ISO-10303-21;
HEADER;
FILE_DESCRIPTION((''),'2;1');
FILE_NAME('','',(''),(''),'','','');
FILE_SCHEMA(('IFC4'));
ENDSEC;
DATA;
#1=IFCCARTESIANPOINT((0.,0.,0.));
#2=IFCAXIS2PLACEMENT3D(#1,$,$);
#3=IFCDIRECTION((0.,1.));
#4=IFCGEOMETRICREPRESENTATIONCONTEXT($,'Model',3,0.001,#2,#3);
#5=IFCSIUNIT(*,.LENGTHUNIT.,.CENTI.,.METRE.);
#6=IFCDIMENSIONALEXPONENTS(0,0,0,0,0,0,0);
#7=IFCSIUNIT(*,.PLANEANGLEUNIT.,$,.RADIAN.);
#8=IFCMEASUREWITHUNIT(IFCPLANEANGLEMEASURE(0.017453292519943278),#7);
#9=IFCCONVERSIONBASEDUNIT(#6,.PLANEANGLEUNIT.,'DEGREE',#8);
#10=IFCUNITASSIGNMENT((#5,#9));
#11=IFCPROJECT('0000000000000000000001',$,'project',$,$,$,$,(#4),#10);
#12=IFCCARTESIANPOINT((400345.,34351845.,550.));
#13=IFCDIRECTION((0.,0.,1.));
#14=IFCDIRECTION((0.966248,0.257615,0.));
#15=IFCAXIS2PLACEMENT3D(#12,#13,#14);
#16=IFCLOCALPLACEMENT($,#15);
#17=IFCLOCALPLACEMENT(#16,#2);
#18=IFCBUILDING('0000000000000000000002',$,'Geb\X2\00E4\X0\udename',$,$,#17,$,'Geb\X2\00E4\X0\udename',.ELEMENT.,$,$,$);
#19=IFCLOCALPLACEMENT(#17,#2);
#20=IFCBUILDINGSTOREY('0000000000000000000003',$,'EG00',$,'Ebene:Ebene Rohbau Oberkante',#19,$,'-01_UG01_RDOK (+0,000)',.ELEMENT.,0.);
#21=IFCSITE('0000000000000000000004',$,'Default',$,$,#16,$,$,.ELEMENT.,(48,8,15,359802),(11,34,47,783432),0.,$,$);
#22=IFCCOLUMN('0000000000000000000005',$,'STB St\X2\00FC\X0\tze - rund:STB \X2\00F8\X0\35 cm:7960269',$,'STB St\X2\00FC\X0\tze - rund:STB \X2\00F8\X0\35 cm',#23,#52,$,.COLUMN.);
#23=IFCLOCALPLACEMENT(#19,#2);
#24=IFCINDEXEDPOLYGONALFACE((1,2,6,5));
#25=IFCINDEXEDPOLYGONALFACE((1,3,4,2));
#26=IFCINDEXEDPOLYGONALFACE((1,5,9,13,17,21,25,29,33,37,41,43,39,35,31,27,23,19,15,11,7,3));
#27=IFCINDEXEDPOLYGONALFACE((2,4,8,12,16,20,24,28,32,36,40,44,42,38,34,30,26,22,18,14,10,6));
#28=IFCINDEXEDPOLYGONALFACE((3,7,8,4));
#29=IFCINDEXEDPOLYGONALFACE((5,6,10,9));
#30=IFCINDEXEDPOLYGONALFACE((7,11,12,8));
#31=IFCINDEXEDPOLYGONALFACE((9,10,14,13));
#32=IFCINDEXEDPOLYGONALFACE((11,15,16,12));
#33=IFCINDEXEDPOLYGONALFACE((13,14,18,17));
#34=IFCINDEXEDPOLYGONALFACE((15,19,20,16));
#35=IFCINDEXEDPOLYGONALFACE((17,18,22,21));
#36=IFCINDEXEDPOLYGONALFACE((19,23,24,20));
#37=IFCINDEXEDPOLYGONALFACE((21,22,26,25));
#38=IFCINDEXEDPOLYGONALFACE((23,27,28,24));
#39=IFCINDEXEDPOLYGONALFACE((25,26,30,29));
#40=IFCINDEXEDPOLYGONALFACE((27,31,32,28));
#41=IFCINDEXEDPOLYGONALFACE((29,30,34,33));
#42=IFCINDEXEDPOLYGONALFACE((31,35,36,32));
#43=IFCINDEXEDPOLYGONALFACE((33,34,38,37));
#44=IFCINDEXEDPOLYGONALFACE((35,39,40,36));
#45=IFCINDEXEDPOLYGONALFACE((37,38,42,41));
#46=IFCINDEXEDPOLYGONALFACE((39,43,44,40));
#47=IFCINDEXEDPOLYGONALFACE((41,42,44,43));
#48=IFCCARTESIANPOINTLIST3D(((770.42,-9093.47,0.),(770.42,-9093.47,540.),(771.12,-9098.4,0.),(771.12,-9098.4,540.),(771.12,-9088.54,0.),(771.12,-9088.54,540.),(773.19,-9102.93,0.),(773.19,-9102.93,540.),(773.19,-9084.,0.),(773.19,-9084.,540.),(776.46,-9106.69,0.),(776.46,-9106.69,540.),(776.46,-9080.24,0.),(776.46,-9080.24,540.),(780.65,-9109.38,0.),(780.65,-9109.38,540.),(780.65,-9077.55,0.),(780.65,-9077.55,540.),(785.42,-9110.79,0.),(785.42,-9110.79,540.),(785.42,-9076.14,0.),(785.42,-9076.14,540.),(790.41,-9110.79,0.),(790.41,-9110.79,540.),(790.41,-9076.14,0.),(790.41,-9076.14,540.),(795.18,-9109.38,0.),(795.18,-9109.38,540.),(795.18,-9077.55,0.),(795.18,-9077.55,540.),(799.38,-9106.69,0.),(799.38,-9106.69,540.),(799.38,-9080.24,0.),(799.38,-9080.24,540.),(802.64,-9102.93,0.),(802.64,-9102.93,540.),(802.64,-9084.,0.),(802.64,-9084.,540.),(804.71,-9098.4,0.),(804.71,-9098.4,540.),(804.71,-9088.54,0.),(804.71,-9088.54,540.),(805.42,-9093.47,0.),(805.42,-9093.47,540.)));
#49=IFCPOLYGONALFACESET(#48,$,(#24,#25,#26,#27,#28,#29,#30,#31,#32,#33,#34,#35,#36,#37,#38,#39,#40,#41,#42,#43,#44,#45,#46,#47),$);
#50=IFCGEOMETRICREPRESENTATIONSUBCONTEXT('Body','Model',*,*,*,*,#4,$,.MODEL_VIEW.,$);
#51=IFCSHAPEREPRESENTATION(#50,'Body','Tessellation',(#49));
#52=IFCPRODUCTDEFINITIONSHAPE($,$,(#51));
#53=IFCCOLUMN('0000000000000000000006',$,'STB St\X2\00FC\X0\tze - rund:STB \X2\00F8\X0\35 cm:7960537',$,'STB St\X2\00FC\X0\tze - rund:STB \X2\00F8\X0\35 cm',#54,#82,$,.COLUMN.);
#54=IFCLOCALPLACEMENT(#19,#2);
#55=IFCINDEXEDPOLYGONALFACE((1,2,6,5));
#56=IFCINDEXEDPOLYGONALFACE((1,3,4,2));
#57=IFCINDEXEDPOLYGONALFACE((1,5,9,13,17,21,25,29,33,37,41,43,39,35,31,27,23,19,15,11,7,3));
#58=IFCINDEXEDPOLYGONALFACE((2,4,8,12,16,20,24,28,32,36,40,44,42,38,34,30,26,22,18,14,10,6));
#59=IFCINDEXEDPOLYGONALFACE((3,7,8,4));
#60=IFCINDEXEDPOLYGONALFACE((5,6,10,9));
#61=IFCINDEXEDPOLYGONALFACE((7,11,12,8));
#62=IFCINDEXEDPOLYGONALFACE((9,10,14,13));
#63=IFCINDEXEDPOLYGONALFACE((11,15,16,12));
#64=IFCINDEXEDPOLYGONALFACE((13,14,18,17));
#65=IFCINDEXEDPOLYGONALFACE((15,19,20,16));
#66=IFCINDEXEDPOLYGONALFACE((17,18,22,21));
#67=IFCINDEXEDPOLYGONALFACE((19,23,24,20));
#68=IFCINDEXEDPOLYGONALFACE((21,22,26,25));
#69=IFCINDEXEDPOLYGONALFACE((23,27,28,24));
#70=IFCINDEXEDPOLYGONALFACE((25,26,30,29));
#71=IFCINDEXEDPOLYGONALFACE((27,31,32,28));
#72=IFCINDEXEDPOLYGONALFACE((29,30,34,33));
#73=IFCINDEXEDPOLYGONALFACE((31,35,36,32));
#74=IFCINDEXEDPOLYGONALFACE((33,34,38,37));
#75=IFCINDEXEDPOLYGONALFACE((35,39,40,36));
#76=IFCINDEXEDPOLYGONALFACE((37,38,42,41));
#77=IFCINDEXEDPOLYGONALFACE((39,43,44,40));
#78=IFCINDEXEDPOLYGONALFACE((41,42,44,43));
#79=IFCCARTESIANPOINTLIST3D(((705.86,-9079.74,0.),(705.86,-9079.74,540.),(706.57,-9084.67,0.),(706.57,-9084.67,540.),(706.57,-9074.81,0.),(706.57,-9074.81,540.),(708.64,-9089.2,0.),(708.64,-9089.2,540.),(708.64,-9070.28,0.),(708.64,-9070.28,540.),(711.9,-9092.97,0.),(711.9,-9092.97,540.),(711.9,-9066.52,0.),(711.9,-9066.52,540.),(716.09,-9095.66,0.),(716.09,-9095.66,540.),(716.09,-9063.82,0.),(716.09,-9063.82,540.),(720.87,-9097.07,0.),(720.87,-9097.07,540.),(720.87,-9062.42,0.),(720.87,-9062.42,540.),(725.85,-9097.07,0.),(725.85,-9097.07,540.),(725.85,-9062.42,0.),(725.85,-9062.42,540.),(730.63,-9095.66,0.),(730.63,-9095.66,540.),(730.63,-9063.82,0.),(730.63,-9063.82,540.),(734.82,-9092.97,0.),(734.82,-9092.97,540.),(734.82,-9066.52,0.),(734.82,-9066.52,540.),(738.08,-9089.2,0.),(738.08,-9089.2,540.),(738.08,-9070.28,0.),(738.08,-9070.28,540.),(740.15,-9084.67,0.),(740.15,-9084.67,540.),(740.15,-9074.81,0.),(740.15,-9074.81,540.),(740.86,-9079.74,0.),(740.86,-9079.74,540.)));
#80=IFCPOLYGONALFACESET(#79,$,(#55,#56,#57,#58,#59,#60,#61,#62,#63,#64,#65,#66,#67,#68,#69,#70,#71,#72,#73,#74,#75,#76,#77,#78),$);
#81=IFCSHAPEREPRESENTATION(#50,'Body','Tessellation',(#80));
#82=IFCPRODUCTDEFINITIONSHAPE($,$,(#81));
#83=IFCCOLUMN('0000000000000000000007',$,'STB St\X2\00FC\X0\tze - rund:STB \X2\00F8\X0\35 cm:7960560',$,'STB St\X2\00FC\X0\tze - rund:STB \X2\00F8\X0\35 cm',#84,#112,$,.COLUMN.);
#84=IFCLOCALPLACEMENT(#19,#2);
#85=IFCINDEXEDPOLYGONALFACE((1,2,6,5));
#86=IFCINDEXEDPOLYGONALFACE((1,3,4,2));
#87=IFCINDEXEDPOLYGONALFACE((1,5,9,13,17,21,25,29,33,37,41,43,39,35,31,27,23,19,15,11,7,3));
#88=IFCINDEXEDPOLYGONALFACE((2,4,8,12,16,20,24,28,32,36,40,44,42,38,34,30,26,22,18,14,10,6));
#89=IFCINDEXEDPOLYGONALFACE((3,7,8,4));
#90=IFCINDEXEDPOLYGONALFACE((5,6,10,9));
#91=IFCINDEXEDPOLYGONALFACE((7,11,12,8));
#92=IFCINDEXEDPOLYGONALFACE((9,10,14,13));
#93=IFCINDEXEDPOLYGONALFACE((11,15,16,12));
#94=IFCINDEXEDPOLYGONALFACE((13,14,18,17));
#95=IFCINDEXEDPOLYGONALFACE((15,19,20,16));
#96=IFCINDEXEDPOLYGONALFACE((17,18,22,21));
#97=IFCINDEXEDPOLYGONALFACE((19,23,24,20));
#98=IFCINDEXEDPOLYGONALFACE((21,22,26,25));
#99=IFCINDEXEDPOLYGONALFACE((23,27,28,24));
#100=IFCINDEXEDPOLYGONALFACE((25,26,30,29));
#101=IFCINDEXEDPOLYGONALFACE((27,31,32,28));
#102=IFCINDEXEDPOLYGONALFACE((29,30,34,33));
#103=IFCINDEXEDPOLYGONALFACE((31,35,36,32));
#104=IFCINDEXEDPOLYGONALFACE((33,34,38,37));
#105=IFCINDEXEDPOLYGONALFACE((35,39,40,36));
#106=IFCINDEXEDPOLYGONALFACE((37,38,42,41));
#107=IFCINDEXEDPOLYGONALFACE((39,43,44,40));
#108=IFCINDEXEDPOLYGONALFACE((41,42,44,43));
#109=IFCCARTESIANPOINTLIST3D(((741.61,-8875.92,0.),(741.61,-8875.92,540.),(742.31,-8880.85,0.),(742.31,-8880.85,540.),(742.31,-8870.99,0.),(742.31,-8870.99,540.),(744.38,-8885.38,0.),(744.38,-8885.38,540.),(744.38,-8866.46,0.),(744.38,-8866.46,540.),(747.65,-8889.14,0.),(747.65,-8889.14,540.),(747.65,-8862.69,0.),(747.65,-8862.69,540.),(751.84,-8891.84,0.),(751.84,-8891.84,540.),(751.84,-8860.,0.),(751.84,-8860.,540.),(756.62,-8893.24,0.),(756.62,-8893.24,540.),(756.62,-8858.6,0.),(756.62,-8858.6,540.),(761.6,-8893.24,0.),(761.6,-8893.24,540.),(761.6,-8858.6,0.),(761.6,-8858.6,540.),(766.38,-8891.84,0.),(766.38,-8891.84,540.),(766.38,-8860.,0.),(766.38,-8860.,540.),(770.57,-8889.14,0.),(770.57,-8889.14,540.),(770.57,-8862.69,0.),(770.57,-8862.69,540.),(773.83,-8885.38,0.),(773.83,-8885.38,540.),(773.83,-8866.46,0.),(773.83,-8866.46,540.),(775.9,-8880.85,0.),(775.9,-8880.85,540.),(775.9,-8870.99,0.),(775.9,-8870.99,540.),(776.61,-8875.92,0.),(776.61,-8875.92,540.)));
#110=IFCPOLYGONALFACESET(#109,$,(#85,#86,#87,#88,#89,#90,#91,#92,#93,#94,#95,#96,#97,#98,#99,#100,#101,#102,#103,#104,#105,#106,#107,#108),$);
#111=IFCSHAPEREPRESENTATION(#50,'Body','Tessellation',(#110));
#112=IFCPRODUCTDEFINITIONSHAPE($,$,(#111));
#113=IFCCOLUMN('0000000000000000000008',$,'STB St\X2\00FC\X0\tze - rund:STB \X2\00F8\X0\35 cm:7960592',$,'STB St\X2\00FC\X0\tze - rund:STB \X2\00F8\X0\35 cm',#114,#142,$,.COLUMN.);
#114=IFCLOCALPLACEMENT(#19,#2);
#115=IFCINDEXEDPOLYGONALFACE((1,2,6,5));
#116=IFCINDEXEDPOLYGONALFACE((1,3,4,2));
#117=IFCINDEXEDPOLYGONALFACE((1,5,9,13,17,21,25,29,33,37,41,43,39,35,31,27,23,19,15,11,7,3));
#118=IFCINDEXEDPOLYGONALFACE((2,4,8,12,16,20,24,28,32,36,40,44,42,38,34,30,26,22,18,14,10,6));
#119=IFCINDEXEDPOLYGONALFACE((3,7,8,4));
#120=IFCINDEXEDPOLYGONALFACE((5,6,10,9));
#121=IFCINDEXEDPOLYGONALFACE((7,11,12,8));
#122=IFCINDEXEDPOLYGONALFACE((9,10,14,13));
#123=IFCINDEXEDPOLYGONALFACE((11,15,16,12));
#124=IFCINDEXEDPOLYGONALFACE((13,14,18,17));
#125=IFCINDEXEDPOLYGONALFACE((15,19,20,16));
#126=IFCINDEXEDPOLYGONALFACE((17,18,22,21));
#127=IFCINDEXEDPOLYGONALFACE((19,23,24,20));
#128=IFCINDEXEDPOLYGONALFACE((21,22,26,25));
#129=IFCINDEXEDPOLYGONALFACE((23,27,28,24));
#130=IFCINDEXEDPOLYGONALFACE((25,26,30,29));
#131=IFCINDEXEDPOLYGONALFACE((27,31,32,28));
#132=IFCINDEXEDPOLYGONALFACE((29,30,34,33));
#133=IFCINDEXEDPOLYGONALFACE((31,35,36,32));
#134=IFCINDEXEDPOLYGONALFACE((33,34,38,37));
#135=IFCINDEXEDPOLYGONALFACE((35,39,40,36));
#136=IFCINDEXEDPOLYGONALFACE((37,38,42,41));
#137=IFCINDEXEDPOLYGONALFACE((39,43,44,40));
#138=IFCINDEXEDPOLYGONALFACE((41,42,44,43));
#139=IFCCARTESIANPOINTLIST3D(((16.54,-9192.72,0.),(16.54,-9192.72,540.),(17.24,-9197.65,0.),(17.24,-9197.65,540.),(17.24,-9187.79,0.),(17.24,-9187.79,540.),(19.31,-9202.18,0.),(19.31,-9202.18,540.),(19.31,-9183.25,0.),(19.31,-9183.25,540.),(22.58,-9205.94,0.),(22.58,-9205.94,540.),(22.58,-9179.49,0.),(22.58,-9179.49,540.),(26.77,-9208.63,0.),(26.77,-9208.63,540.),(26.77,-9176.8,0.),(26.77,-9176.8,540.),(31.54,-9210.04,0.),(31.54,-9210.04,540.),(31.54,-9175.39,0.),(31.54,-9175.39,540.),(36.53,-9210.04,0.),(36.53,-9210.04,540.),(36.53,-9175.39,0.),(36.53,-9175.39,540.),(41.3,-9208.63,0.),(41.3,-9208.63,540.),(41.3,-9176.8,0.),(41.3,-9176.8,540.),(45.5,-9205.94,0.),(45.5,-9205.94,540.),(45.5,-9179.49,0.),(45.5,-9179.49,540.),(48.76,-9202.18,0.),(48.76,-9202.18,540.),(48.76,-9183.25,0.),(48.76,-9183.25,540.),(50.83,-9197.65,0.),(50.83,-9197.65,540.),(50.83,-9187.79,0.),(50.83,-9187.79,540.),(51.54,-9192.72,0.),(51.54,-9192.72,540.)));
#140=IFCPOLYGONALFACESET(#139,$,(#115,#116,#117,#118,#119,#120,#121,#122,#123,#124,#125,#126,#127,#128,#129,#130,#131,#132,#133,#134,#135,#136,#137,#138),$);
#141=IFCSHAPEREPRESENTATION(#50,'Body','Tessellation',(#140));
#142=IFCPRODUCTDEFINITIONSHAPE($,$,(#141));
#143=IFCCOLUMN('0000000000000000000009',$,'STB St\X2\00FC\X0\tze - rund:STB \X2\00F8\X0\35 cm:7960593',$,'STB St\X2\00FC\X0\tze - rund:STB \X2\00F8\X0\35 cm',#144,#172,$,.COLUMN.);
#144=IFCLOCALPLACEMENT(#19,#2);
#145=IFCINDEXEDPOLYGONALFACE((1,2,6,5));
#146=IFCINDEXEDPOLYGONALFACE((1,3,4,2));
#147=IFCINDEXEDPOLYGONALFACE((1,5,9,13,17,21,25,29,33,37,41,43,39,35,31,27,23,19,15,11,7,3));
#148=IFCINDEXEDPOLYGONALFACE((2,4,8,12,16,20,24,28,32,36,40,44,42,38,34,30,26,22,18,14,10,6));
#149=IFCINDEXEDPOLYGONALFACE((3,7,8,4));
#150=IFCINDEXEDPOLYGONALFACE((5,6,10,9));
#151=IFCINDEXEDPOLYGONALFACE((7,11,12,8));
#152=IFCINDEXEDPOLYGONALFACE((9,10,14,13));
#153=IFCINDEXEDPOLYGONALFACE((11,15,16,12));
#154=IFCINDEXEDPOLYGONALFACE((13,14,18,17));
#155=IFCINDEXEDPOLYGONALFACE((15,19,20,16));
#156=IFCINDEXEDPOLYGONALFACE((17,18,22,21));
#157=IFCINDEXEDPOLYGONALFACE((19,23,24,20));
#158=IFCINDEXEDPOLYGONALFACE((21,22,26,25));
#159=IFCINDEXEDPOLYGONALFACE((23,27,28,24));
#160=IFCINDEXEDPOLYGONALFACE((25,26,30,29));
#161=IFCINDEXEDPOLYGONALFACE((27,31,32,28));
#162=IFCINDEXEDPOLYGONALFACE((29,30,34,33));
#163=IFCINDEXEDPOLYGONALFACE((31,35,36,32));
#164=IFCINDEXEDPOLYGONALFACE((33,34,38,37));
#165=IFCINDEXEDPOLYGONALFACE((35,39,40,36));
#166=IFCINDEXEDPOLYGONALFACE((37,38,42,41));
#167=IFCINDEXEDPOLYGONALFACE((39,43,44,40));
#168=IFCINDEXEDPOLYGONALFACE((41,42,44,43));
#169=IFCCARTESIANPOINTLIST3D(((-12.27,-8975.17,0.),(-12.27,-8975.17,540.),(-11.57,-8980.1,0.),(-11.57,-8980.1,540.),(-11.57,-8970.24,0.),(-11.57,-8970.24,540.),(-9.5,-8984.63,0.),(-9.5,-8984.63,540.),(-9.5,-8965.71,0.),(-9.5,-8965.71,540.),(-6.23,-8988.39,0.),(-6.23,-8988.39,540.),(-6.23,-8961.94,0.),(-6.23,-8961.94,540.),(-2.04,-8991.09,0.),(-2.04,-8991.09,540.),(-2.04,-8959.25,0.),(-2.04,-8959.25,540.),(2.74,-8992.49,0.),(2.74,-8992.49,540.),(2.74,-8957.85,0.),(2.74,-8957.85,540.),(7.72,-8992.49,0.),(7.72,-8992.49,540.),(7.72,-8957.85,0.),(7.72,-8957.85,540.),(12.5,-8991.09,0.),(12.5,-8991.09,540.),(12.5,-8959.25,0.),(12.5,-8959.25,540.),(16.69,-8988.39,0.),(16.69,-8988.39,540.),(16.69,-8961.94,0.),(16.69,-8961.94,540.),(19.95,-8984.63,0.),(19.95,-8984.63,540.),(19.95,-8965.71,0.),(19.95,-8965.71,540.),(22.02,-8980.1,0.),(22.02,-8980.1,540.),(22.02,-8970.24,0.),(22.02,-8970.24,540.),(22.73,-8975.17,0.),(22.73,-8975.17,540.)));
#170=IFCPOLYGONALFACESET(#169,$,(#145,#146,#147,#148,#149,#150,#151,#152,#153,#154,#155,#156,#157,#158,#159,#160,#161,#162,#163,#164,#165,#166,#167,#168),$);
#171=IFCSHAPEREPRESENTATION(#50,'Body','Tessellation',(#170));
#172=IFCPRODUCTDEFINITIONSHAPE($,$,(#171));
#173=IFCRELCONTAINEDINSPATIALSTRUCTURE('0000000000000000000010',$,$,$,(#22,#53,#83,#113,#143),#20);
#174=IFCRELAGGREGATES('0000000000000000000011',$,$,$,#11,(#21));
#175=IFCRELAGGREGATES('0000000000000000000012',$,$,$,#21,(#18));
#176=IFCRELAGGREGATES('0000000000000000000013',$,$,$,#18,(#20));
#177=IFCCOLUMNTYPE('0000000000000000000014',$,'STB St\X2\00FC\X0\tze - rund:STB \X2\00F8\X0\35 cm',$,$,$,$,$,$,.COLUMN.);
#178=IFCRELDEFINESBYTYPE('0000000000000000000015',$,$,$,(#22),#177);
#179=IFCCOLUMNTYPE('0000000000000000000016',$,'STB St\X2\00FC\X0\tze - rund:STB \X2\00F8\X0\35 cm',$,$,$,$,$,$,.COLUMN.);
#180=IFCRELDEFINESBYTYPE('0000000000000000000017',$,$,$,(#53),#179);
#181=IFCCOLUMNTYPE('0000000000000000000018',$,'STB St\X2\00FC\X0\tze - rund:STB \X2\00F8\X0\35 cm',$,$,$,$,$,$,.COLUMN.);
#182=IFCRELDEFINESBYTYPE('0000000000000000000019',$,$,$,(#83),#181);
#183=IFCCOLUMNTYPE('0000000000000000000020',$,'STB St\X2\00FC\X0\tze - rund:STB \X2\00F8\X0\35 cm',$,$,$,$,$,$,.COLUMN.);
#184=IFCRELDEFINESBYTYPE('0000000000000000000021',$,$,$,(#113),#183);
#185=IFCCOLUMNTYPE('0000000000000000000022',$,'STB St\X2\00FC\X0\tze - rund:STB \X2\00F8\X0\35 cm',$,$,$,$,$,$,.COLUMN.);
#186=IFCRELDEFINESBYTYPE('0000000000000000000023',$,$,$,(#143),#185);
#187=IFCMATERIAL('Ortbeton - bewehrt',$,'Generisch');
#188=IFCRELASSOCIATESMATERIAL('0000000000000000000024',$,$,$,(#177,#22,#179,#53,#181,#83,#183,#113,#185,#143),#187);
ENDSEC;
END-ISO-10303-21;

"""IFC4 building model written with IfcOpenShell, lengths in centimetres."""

from ifc_helpers import new_model, entity, si_unit, converted_unit, direction, frame, origin, place, context, subcontext, project, spatial, arc, indexed_curve, outline, extrude, source, transform, mapped, material, type_object, type_shapes, element, save


model = new_model("IFC4")

# Units and contexts
model_context = context("Model", 3, precision=0.001, world=origin(), true_north=direction((0.0, 1.0)))
body_context = subcontext(model_context, "Body", "Model", "MODEL_VIEW")
ifc_project = project(units=[si_unit("LENGTHUNIT", "METRE", prefix="CENTI"), converted_unit("PLANEANGLEUNIT", "DEGREE", entity("IfcPlaneAngleMeasure", 0.017453292519943278), si_unit("PLANEANGLEUNIT", "RADIAN"), dimensions=[0, 0, 0, 0, 0, 0, 0])], contexts=[model_context])

# Site, building, storey
site_placement = place(None, frame((400345.0, 34351845.0, 550.0), z_axis=(0.0, 0.0, 1.0), x_axis=(0.966248, 0.257615, 0.0)))
site = spatial("IfcSite", under=ifc_project, at=site_placement, Name="Default", CompositionType="ELEMENT", RefLatitude=(48, 8, 15, 359802), RefLongitude=(11, 34, 47, 783432), RefElevation=0.0)
building_placement = place(site_placement, origin())
building = spatial("IfcBuilding", under=site, at=building_placement, Name="Gebäudename", LongName="Gebäudename", CompositionType="ELEMENT")
storey_placement = place(building_placement, origin())
storey = spatial("IfcBuildingStorey", under=building, at=storey_placement, Name="EG00", ObjectType="Ebene:Ebene Rohbau Oberkante", LongName="-01_UG01_RDOK (+0,000)", CompositionType="ELEMENT", Elevation=0.0)

# Columns
ifc_material = material(Name="Ortbeton - bewehrt", Category="Generisch")
column_type_1 = type_object("IfcColumnType", Name="STB Stütze - rund:STB ø35 cm", PredefinedType="COLUMN", material=ifc_material)
shared_shape_1 = source(origin(), body_context, "Body", "SweptSolid", [
    extrude(outline(indexed_curve([(-17.5, 0.0), (0.0, -17.5), (17.5, 0.0), (0.0, 17.5)], segments=[arc(1, 2, 3), arc(3, 4, 1)], self_intersect=False)), frame((787.92, -9093.47, 0.0)), (0.0, 0.0, 1.0), 540.0),
])
type_shapes(column_type_1, [shared_shape_1])
column_1_placement = place(storey_placement, origin())
element("IfcColumn", 1, at=column_1_placement, inside=storey, type_object=column_type_1, material=ifc_material, Name="STB Stütze - rund:STB ø35 cm:7960269", ObjectType="STB Stütze - rund:STB ø35 cm", PredefinedType="COLUMN", context=body_context, shape_type="MappedRepresentation", body=[
    mapped(shared_shape_1, transform((0.0, 0.0, 0.0), scale=1.0)),
])
column_type_2 = type_object("IfcColumnType", Name="STB Stütze - rund:STB ø35 cm", PredefinedType="COLUMN", material=ifc_material)
shared_shape_2 = source(origin(), body_context, "Body", "SweptSolid", [
    extrude(outline(indexed_curve([(-17.5, 0.0), (0.0, -17.5), (17.5, 0.0), (0.0, 17.5)], segments=[arc(1, 2, 3), arc(3, 4, 1)], self_intersect=False)), frame((723.36, -9079.74, 0.0)), (0.0, 0.0, 1.0), 540.0),
])
type_shapes(column_type_2, [shared_shape_2])
column_2_placement = place(storey_placement, origin())
element("IfcColumn", 2, at=column_2_placement, inside=storey, type_object=column_type_2, material=ifc_material, Name="STB Stütze - rund:STB ø35 cm:7960537", ObjectType="STB Stütze - rund:STB ø35 cm", PredefinedType="COLUMN", context=body_context, shape_type="MappedRepresentation", body=[
    mapped(shared_shape_2, transform((0.0, 0.0, 0.0), scale=1.0)),
])
column_type_3 = type_object("IfcColumnType", Name="STB Stütze - rund:STB ø35 cm", PredefinedType="COLUMN", material=ifc_material)
shared_shape_3 = source(origin(), body_context, "Body", "SweptSolid", [
    extrude(outline(indexed_curve([(-17.5, 0.0), (0.0, -17.5), (17.5, 0.0), (0.0, 17.5)], segments=[arc(1, 2, 3), arc(3, 4, 1)], self_intersect=False)), frame((759.11, -8875.92, 0.0)), (0.0, 0.0, 1.0), 540.0),
])
type_shapes(column_type_3, [shared_shape_3])
column_3_placement = place(storey_placement, origin())
element("IfcColumn", 3, at=column_3_placement, inside=storey, type_object=column_type_3, material=ifc_material, Name="STB Stütze - rund:STB ø35 cm:7960560", ObjectType="STB Stütze - rund:STB ø35 cm", PredefinedType="COLUMN", context=body_context, shape_type="MappedRepresentation", body=[
    mapped(shared_shape_3, transform((0.0, 0.0, 0.0), scale=1.0)),
])
column_type_4 = type_object("IfcColumnType", Name="STB Stütze - rund:STB ø35 cm", PredefinedType="COLUMN", material=ifc_material)
shared_shape_4 = source(origin(), body_context, "Body", "SweptSolid", [
    extrude(outline(indexed_curve([(-17.5, 0.0), (0.0, -17.5), (17.5, 0.0), (0.0, 17.5)], segments=[arc(1, 2, 3), arc(3, 4, 1)], self_intersect=False)), frame((34.04, -9192.72, 0.0)), (0.0, 0.0, 1.0), 540.0),
])
type_shapes(column_type_4, [shared_shape_4])
column_4_placement = place(storey_placement, origin())
element("IfcColumn", 4, at=column_4_placement, inside=storey, type_object=column_type_4, material=ifc_material, Name="STB Stütze - rund:STB ø35 cm:7960592", ObjectType="STB Stütze - rund:STB ø35 cm", PredefinedType="COLUMN", context=body_context, shape_type="MappedRepresentation", body=[
    mapped(shared_shape_4, transform((0.0, 0.0, 0.0), scale=1.0)),
])
column_type_5 = type_object("IfcColumnType", Name="STB Stütze - rund:STB ø35 cm", PredefinedType="COLUMN", material=ifc_material)
shared_shape_5 = source(origin(), body_context, "Body", "SweptSolid", [
    extrude(outline(indexed_curve([(-17.5, 0.0), (0.0, -17.5), (17.5, 0.0), (0.0, 17.5)], segments=[arc(1, 2, 3), arc(3, 4, 1)], self_intersect=False)), frame((5.23, -8975.17, 0.0)), (0.0, 0.0, 1.0), 540.0),
])
type_shapes(column_type_5, [shared_shape_5])
column_5_placement = place(storey_placement, origin())
element("IfcColumn", 5, at=column_5_placement, inside=storey, type_object=column_type_5, material=ifc_material, Name="STB Stütze - rund:STB ø35 cm:7960593", ObjectType="STB Stütze - rund:STB ø35 cm", PredefinedType="COLUMN", context=body_context, shape_type="MappedRepresentation", body=[
    mapped(shared_shape_5, transform((0.0, 0.0, 0.0), scale=1.0)),
])

save(model, "model.ifc")
